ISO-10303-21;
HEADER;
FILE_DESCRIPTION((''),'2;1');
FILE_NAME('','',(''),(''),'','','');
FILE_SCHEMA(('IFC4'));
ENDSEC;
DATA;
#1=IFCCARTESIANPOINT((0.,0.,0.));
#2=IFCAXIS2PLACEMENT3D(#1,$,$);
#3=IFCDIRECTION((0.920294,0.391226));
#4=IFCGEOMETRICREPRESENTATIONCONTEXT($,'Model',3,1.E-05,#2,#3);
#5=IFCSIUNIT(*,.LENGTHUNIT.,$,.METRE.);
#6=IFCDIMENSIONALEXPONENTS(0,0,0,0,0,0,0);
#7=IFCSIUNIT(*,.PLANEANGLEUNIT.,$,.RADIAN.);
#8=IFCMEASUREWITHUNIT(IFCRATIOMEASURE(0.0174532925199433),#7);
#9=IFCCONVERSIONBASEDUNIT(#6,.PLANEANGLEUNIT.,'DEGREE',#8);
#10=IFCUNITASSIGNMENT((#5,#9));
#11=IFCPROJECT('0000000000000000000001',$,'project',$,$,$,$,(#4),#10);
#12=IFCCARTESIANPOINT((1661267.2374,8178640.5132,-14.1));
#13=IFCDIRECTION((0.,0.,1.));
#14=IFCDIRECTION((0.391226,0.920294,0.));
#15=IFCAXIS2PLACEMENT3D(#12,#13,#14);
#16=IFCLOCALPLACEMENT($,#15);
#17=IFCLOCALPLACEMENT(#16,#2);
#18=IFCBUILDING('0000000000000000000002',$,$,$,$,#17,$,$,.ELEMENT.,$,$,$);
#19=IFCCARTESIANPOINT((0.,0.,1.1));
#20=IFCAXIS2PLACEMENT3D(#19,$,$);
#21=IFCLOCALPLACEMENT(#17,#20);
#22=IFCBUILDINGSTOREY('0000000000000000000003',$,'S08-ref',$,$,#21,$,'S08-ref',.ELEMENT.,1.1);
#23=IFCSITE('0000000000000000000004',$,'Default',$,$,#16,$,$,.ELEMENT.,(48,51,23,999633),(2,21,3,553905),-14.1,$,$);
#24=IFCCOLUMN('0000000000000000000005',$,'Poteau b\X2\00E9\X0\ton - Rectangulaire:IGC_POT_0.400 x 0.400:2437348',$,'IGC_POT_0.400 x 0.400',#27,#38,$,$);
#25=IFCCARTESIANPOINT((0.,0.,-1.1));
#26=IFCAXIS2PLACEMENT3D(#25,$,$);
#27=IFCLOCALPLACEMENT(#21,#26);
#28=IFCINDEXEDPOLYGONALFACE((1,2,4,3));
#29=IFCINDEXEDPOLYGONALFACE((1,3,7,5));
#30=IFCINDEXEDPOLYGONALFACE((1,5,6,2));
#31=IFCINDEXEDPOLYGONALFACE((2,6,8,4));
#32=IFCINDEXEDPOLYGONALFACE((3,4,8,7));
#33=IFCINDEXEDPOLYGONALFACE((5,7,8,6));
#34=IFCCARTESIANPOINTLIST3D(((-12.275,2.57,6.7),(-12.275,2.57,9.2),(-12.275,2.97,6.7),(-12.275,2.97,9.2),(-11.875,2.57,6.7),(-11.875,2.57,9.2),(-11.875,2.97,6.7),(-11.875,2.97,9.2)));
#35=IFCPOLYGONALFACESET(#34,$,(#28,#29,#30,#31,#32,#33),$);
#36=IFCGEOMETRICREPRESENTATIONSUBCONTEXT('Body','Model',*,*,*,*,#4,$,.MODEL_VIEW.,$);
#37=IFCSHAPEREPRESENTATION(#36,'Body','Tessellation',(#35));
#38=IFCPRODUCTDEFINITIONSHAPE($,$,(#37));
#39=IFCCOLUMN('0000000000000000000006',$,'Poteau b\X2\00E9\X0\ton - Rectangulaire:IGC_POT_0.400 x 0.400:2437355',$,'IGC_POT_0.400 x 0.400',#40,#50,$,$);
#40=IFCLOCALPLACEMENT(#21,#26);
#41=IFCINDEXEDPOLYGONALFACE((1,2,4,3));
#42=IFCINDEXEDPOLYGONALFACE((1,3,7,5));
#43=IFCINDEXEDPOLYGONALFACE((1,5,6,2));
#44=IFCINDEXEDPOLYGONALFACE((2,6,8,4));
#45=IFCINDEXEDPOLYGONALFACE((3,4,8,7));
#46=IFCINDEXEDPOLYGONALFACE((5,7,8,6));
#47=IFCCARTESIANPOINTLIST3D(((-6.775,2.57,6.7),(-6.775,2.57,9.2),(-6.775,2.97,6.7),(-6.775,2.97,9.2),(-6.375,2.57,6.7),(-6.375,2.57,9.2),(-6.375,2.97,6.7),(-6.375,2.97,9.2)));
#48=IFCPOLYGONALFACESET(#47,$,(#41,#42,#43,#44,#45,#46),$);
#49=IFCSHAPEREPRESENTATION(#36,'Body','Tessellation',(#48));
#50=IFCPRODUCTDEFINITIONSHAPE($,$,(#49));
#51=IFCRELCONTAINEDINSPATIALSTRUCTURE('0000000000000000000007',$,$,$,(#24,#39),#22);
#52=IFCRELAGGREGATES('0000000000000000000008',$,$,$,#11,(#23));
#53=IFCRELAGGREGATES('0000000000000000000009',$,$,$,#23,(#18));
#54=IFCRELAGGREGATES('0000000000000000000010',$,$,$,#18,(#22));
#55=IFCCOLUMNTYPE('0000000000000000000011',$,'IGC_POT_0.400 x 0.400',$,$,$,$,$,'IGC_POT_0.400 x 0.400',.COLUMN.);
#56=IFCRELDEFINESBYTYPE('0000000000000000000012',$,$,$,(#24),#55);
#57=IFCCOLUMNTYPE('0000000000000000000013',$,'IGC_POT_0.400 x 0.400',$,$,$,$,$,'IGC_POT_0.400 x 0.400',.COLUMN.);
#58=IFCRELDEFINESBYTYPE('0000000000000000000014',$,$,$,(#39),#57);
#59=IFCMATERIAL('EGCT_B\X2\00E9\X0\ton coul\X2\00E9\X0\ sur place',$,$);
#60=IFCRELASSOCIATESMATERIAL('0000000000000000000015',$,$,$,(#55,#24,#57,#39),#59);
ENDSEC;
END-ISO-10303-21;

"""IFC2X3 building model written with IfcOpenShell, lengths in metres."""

from ifc_helpers import new_model, entity, si_unit, converted_unit, direction, frame, origin, origin_2d_with_axis, place, context, subcontext, project, spatial, rectangle, extrude, source, transform, mapped, material, type_object, type_shapes, element, save


model = new_model("IFC2X3")

# Units and contexts
model_context = context("Model", 3, precision=1e-05, world=origin(), true_north=direction((0.920294, 0.391226)))
body_context = subcontext(model_context, "Body", "Model", "MODEL_VIEW")
ifc_project = project(units=[si_unit("LENGTHUNIT", "METRE"), converted_unit("PLANEANGLEUNIT", "DEGREE", entity("IfcRatioMeasure", 0.0174532925199433), si_unit("PLANEANGLEUNIT", "RADIAN"), dimensions=[0, 0, 0, 0, 0, 0, 0])], contexts=[model_context])

# Site, building, storey
site_placement = place(None, frame((1661267.2374, 8178640.5132, -14.1), z_axis=(0.0, 0.0, 1.0), x_axis=(0.391226, 0.920294, 0.0)))
site = spatial("IfcSite", under=ifc_project, at=site_placement, Name="Default", CompositionType="ELEMENT", RefLatitude=(48, 51, 23, 999633), RefLongitude=(2, 21, 3, 553905), RefElevation=-14.1)
building_placement = place(site_placement, origin())
building = spatial("IfcBuilding", under=site, at=building_placement, CompositionType="ELEMENT")
storey_placement = place(building_placement, frame((0.0, 0.0, 1.1)))
storey = spatial("IfcBuildingStorey", under=building, at=storey_placement, Name="S08-ref", LongName="S08-ref", CompositionType="ELEMENT", Elevation=1.1)

# Columns
ifc_material_1 = material(Name="EGCT_Béton coulé sur place")
column_type_1 = type_object("IfcColumnType", Name="IGC_POT_0.400 x 0.400", ElementType="IGC_POT_0.400 x 0.400", PredefinedType="COLUMN", material=ifc_material_1)
shared_shape_1 = source(origin(), body_context, "Body", "SweptSolid", [
    extrude(rectangle(XDim=0.4, YDim=0.4, at=origin_2d_with_axis()), frame((-12.075, 2.77, 6.7), z_axis=(0.0, 0.0, 1.0), x_axis=(0.0, -1.0, 0.0)), (0.0, 0.0, 1.0), 2.5),
])
type_shapes(column_type_1, [shared_shape_1])
column_1_placement = place(storey_placement, frame((0.0, 0.0, -1.1)))
element("IfcColumn", 1, at=column_1_placement, inside=storey, type_object=column_type_1, material=ifc_material_1, Name="Poteau béton - Rectangulaire:IGC_POT_0.400 x 0.400:2437348", ObjectType="IGC_POT_0.400 x 0.400", context=body_context, shape_type="MappedRepresentation", body=[
    mapped(shared_shape_1, transform((0.0, 0.0, 0.0), scale=1.0)),
])
column_type_2 = type_object("IfcColumnType", Name="IGC_POT_0.400 x 0.400", ElementType="IGC_POT_0.400 x 0.400", PredefinedType="COLUMN", material=ifc_material_1)
shared_shape_2 = source(origin(), body_context, "Body", "SweptSolid", [
    extrude(rectangle(XDim=0.4, YDim=0.4, at=origin_2d_with_axis()), frame((-6.575, 2.77, 6.7), z_axis=(0.0, 0.0, 1.0), x_axis=(0.0, -1.0, 0.0)), (0.0, 0.0, 1.0), 2.5),
])
type_shapes(column_type_2, [shared_shape_2])
column_2_placement = place(storey_placement, frame((0.0, 0.0, -1.1)))
element("IfcColumn", 2, at=column_2_placement, inside=storey, type_object=column_type_2, material=ifc_material_1, Name="Poteau béton - Rectangulaire:IGC_POT_0.400 x 0.400:2437355", ObjectType="IGC_POT_0.400 x 0.400", context=body_context, shape_type="MappedRepresentation", body=[
    mapped(shared_shape_2, transform((0.0, 0.0, 0.0), scale=1.0)),
])

save(model, "model.ifc")
